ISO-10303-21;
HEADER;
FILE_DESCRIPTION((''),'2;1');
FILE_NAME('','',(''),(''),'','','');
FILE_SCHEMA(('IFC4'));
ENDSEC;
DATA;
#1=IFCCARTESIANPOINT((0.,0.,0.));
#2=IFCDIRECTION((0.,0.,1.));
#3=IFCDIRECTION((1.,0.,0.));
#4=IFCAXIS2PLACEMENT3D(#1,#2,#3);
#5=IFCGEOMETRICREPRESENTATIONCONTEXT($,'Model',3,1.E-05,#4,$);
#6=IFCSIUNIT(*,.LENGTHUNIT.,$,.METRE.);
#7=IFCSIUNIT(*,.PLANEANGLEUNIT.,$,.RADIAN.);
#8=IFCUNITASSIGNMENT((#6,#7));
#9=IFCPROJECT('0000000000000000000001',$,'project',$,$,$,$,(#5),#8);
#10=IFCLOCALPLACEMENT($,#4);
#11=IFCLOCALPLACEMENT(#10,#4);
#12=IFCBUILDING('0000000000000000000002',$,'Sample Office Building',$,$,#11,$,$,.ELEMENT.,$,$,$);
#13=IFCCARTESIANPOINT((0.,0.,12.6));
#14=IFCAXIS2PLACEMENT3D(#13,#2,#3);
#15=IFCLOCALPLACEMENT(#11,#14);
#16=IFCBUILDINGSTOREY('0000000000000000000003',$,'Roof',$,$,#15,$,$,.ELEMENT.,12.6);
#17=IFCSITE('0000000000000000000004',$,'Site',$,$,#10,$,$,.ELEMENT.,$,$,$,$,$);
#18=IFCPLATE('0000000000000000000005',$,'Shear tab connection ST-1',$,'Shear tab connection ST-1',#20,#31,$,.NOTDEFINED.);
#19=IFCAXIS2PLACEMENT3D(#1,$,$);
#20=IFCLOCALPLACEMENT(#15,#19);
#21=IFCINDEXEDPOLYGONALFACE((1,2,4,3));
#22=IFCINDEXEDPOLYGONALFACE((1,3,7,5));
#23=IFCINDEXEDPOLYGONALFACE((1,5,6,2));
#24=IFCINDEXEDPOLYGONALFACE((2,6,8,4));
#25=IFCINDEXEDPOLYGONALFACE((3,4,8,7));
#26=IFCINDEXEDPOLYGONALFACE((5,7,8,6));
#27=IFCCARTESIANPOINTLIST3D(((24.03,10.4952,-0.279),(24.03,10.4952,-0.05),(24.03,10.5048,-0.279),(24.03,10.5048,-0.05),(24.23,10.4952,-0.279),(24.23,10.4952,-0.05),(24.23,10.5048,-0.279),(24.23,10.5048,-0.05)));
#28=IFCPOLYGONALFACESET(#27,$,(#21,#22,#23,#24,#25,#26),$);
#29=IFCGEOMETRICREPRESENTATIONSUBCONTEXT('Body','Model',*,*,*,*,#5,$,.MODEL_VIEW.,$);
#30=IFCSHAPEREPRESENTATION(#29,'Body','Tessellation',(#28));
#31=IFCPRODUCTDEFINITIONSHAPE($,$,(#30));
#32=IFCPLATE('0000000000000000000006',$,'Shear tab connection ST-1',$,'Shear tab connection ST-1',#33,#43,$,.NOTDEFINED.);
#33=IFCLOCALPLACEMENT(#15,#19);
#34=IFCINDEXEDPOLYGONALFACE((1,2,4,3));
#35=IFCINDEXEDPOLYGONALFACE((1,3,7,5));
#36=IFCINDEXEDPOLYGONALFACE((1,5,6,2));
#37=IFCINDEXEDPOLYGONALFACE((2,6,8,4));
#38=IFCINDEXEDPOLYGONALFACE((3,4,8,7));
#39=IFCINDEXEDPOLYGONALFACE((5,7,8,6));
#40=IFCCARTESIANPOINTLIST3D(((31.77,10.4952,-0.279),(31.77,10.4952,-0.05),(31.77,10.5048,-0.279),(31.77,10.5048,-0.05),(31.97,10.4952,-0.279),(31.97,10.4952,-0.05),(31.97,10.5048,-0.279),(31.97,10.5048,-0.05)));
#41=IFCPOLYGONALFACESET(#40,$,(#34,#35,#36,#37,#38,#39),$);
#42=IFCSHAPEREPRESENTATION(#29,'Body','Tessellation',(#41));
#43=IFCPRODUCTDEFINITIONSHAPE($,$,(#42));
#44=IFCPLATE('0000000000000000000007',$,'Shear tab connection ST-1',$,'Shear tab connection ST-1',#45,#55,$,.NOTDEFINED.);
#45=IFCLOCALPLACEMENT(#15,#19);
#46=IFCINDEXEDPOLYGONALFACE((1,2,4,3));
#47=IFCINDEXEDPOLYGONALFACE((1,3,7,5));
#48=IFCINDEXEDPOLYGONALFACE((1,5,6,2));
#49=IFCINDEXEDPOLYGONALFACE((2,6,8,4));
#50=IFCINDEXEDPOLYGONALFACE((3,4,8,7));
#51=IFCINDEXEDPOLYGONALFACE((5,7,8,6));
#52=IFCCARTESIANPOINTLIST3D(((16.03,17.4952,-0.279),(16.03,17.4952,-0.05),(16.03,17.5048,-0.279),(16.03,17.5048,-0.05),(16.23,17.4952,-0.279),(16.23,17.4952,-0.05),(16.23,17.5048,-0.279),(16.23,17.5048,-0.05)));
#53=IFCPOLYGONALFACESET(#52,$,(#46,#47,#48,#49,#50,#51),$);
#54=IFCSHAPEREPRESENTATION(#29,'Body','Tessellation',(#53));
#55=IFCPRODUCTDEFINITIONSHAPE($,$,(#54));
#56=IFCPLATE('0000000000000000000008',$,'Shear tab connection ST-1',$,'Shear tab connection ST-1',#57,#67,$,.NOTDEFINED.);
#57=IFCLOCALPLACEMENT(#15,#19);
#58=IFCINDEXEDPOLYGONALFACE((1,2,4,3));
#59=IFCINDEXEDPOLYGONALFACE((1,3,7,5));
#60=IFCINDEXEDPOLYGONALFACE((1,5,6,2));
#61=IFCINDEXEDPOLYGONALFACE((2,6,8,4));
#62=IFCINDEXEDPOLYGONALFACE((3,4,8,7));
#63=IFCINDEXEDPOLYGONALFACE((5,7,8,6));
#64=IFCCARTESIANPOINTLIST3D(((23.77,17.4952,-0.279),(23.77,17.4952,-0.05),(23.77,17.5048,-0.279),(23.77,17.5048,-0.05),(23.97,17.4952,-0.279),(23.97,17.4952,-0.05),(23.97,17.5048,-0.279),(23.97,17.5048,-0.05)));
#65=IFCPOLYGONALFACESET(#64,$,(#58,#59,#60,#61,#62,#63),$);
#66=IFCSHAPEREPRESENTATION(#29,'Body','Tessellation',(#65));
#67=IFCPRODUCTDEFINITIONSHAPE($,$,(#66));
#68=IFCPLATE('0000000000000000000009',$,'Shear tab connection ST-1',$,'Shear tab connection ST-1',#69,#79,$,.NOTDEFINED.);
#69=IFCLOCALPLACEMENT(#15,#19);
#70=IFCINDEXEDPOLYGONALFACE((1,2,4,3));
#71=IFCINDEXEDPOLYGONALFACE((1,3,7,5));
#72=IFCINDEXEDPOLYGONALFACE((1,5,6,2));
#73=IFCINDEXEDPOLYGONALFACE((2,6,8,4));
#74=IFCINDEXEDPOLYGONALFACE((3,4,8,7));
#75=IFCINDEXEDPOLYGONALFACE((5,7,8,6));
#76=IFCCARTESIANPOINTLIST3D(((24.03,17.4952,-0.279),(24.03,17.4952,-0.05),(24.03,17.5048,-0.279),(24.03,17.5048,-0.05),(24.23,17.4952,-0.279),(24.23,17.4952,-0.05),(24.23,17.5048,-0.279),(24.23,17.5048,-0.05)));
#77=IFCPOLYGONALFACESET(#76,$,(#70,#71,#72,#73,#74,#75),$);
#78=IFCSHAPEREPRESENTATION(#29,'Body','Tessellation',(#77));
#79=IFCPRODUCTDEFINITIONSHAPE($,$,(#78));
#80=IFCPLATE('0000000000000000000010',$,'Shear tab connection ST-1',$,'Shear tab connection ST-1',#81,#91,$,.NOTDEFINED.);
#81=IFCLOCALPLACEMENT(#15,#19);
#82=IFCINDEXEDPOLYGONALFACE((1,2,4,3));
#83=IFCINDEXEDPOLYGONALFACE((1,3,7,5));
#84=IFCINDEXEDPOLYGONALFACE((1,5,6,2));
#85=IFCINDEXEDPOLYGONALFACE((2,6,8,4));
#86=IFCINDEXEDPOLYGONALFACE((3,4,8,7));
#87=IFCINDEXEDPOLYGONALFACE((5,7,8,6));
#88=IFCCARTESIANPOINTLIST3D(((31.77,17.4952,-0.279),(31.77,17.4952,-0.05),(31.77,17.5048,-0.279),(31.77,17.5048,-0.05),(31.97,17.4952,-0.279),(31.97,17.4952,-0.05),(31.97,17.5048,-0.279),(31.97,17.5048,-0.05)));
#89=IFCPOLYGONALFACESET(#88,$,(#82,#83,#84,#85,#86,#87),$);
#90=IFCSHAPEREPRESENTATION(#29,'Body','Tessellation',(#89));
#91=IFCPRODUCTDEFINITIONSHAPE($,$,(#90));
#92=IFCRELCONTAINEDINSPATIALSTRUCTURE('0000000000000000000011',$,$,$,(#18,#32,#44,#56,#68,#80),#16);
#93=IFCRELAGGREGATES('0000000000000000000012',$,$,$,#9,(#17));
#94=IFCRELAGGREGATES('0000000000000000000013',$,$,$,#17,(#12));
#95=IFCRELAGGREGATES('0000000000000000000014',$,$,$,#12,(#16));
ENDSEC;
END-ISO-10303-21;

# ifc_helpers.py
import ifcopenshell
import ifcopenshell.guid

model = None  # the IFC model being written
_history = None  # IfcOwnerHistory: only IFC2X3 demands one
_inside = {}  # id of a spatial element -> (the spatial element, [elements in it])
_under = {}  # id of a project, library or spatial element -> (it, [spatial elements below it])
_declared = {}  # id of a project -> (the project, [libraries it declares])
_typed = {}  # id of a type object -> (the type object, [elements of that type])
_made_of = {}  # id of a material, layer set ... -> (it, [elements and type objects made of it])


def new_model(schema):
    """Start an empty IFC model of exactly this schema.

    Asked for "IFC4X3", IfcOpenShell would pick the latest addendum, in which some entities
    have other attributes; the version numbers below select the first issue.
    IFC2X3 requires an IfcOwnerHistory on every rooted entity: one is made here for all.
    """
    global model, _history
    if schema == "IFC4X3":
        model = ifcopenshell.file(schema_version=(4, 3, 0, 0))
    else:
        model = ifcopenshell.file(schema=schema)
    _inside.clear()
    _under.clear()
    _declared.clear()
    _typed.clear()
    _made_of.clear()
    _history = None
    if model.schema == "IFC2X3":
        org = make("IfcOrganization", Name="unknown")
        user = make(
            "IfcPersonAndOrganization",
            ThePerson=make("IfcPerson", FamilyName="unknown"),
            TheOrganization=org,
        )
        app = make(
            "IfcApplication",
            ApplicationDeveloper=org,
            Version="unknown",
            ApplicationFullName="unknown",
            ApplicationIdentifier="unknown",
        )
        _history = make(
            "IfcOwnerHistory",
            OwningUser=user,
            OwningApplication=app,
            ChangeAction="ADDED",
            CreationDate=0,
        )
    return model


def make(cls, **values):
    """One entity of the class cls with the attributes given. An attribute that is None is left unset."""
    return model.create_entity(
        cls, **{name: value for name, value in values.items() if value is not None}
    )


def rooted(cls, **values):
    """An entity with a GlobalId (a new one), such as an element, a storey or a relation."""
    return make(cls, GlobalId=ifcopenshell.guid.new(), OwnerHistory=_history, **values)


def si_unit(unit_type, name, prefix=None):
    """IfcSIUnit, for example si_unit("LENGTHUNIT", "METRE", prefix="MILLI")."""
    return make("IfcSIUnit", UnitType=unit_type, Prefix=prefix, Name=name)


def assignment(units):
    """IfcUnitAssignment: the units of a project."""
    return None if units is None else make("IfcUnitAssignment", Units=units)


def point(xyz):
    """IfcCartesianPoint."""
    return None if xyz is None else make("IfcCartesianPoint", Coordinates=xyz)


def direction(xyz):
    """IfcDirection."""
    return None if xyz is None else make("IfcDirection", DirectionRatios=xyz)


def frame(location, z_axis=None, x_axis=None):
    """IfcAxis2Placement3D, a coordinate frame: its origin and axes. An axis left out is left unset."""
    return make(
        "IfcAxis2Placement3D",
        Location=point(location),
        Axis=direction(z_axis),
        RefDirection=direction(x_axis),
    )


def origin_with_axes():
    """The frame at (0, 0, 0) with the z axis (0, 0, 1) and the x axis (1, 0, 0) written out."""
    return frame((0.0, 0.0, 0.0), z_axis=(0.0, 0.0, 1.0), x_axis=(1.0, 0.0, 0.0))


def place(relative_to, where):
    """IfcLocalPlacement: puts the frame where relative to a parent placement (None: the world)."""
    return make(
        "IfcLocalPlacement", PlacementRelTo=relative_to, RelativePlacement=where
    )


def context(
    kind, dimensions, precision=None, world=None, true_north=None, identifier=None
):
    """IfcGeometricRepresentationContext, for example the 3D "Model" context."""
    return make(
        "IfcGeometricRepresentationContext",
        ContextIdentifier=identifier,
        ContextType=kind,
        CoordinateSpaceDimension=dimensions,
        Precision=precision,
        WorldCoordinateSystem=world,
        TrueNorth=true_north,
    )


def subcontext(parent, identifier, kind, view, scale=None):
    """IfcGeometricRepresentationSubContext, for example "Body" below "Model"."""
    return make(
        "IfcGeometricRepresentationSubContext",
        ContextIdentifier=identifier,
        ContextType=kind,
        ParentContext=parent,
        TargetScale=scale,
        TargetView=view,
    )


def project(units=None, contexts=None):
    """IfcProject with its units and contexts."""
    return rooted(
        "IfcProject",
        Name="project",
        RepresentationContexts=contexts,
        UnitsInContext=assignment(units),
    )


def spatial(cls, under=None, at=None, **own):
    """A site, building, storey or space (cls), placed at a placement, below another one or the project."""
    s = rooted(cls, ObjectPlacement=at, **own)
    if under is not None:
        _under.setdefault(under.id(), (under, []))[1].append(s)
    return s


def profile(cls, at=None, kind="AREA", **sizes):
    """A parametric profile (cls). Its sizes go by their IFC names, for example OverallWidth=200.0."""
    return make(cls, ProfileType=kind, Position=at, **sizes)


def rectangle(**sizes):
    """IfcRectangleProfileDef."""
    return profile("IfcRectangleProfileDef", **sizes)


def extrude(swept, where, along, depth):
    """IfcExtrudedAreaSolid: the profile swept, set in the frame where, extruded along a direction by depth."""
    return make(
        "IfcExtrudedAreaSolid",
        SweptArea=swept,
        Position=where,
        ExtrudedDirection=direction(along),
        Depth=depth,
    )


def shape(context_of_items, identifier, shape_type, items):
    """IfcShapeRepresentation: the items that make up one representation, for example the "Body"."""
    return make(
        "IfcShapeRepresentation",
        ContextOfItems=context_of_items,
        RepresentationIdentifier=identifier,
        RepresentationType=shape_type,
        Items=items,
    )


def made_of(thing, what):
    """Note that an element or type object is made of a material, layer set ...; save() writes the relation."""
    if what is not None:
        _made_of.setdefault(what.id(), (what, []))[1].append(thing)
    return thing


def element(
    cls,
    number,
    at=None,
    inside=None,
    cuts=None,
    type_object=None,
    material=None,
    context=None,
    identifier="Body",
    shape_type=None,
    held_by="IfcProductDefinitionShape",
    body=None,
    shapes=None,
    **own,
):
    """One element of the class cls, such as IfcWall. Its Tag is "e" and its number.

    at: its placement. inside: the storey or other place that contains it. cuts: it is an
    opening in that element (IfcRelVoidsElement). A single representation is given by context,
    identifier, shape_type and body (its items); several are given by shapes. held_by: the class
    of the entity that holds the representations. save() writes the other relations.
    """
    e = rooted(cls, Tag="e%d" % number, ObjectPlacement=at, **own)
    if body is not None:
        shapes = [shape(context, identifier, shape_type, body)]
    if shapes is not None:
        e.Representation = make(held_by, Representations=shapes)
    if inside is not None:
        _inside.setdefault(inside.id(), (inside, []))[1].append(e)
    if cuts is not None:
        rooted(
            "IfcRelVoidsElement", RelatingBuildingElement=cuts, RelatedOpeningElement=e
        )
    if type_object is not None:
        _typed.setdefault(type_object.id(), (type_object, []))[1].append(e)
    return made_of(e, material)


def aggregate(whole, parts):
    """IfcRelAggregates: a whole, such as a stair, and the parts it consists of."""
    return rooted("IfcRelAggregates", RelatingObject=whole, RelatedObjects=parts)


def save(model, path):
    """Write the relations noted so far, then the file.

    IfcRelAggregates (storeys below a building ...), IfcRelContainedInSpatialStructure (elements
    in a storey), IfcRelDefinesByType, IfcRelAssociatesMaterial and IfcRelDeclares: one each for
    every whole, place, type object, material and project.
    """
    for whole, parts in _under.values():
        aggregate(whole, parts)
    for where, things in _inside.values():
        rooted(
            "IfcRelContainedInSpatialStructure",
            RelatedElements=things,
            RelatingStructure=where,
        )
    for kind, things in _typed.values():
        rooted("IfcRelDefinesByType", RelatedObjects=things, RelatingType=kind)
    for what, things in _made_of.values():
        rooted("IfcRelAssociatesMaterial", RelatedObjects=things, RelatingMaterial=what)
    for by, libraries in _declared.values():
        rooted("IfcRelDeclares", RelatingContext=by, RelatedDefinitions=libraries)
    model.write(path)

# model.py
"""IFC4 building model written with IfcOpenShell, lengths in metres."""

from ifc_helpers import new_model, si_unit, frame, origin_with_axes, place, context, subcontext, project, spatial, rectangle, extrude, element, save


model = new_model("IFC4")

# Units and contexts
model_context = context("Model", 3, precision=1e-05, world=origin_with_axes())
body_context = subcontext(model_context, "Body", "Model", "MODEL_VIEW")
ifc_project = project(units=[si_unit("LENGTHUNIT", "METRE"), si_unit("PLANEANGLEUNIT", "RADIAN")], contexts=[model_context])

# Site, building, storey
site_placement = place(None, origin_with_axes())
site = spatial("IfcSite", under=ifc_project, at=site_placement, Name="Site", CompositionType="ELEMENT")
building_placement = place(site_placement, origin_with_axes())
building = spatial("IfcBuilding", under=site, at=building_placement, Name="Sample Office Building", CompositionType="ELEMENT")
storey_placement = place(building_placement, frame((0.0, 0.0, 12.6), z_axis=(0.0, 0.0, 1.0), x_axis=(1.0, 0.0, 0.0)))
storey = spatial("IfcBuildingStorey", under=building, at=storey_placement, Name="Roof", CompositionType="ELEMENT", Elevation=12.6)

# Plates
for number, where, z_axis, x_axis, name in (
    (1, (24.13, 10.5, 12.321), (0.0, 0.0, 1.0), (1.0, 0.0, 0.0), "Shear tab connection ST-1"),
    (2, (31.87, 10.5, 12.321), (0.0, 0.0, 1.0), (1.0, 0.0, 0.0), "Shear tab connection ST-1"),
):
    element("IfcPlate", number, at=place(None, frame(where, z_axis=z_axis, x_axis=x_axis)), inside=storey, Name=name, ObjectType="Shear tab connection ST-1", PredefinedType="NOTDEFINED", context=body_context, shape_type="SweptSolid", body=[
        extrude(rectangle(XDim=0.2, YDim=0.0095), None, (0.0, 0.0, 1.0), 0.229),
    ])
for number, where, z_axis, x_axis, name in (
    (3, (16.13, 17.5, 12.321), (0.0, 0.0, 1.0), (1.0, 0.0, 0.0), "Shear tab connection ST-1"),
    (4, (23.87, 17.5, 12.321), (0.0, 0.0, 1.0), (1.0, 0.0, 0.0), "Shear tab connection ST-1"),
    (5, (24.13, 17.5, 12.321), (0.0, 0.0, 1.0), (1.0, 0.0, 0.0), "Shear tab connection ST-1"),
    (6, (31.87, 17.5, 12.321), (0.0, 0.0, 1.0), (1.0, 0.0, 0.0), "Shear tab connection ST-1"),
):
    element("IfcPlate", number, at=place(None, frame(where, z_axis=z_axis, x_axis=x_axis)), inside=storey, Name=name, ObjectType="Shear tab connection ST-1", PredefinedType="NOTDEFINED", context=body_context, shape_type="SweptSolid", body=[
        extrude(rectangle(XDim=0.2, YDim=0.0095), None, (0.0, 0.0, 1.0), 0.229),
    ])

save(model, "model.ifc")
